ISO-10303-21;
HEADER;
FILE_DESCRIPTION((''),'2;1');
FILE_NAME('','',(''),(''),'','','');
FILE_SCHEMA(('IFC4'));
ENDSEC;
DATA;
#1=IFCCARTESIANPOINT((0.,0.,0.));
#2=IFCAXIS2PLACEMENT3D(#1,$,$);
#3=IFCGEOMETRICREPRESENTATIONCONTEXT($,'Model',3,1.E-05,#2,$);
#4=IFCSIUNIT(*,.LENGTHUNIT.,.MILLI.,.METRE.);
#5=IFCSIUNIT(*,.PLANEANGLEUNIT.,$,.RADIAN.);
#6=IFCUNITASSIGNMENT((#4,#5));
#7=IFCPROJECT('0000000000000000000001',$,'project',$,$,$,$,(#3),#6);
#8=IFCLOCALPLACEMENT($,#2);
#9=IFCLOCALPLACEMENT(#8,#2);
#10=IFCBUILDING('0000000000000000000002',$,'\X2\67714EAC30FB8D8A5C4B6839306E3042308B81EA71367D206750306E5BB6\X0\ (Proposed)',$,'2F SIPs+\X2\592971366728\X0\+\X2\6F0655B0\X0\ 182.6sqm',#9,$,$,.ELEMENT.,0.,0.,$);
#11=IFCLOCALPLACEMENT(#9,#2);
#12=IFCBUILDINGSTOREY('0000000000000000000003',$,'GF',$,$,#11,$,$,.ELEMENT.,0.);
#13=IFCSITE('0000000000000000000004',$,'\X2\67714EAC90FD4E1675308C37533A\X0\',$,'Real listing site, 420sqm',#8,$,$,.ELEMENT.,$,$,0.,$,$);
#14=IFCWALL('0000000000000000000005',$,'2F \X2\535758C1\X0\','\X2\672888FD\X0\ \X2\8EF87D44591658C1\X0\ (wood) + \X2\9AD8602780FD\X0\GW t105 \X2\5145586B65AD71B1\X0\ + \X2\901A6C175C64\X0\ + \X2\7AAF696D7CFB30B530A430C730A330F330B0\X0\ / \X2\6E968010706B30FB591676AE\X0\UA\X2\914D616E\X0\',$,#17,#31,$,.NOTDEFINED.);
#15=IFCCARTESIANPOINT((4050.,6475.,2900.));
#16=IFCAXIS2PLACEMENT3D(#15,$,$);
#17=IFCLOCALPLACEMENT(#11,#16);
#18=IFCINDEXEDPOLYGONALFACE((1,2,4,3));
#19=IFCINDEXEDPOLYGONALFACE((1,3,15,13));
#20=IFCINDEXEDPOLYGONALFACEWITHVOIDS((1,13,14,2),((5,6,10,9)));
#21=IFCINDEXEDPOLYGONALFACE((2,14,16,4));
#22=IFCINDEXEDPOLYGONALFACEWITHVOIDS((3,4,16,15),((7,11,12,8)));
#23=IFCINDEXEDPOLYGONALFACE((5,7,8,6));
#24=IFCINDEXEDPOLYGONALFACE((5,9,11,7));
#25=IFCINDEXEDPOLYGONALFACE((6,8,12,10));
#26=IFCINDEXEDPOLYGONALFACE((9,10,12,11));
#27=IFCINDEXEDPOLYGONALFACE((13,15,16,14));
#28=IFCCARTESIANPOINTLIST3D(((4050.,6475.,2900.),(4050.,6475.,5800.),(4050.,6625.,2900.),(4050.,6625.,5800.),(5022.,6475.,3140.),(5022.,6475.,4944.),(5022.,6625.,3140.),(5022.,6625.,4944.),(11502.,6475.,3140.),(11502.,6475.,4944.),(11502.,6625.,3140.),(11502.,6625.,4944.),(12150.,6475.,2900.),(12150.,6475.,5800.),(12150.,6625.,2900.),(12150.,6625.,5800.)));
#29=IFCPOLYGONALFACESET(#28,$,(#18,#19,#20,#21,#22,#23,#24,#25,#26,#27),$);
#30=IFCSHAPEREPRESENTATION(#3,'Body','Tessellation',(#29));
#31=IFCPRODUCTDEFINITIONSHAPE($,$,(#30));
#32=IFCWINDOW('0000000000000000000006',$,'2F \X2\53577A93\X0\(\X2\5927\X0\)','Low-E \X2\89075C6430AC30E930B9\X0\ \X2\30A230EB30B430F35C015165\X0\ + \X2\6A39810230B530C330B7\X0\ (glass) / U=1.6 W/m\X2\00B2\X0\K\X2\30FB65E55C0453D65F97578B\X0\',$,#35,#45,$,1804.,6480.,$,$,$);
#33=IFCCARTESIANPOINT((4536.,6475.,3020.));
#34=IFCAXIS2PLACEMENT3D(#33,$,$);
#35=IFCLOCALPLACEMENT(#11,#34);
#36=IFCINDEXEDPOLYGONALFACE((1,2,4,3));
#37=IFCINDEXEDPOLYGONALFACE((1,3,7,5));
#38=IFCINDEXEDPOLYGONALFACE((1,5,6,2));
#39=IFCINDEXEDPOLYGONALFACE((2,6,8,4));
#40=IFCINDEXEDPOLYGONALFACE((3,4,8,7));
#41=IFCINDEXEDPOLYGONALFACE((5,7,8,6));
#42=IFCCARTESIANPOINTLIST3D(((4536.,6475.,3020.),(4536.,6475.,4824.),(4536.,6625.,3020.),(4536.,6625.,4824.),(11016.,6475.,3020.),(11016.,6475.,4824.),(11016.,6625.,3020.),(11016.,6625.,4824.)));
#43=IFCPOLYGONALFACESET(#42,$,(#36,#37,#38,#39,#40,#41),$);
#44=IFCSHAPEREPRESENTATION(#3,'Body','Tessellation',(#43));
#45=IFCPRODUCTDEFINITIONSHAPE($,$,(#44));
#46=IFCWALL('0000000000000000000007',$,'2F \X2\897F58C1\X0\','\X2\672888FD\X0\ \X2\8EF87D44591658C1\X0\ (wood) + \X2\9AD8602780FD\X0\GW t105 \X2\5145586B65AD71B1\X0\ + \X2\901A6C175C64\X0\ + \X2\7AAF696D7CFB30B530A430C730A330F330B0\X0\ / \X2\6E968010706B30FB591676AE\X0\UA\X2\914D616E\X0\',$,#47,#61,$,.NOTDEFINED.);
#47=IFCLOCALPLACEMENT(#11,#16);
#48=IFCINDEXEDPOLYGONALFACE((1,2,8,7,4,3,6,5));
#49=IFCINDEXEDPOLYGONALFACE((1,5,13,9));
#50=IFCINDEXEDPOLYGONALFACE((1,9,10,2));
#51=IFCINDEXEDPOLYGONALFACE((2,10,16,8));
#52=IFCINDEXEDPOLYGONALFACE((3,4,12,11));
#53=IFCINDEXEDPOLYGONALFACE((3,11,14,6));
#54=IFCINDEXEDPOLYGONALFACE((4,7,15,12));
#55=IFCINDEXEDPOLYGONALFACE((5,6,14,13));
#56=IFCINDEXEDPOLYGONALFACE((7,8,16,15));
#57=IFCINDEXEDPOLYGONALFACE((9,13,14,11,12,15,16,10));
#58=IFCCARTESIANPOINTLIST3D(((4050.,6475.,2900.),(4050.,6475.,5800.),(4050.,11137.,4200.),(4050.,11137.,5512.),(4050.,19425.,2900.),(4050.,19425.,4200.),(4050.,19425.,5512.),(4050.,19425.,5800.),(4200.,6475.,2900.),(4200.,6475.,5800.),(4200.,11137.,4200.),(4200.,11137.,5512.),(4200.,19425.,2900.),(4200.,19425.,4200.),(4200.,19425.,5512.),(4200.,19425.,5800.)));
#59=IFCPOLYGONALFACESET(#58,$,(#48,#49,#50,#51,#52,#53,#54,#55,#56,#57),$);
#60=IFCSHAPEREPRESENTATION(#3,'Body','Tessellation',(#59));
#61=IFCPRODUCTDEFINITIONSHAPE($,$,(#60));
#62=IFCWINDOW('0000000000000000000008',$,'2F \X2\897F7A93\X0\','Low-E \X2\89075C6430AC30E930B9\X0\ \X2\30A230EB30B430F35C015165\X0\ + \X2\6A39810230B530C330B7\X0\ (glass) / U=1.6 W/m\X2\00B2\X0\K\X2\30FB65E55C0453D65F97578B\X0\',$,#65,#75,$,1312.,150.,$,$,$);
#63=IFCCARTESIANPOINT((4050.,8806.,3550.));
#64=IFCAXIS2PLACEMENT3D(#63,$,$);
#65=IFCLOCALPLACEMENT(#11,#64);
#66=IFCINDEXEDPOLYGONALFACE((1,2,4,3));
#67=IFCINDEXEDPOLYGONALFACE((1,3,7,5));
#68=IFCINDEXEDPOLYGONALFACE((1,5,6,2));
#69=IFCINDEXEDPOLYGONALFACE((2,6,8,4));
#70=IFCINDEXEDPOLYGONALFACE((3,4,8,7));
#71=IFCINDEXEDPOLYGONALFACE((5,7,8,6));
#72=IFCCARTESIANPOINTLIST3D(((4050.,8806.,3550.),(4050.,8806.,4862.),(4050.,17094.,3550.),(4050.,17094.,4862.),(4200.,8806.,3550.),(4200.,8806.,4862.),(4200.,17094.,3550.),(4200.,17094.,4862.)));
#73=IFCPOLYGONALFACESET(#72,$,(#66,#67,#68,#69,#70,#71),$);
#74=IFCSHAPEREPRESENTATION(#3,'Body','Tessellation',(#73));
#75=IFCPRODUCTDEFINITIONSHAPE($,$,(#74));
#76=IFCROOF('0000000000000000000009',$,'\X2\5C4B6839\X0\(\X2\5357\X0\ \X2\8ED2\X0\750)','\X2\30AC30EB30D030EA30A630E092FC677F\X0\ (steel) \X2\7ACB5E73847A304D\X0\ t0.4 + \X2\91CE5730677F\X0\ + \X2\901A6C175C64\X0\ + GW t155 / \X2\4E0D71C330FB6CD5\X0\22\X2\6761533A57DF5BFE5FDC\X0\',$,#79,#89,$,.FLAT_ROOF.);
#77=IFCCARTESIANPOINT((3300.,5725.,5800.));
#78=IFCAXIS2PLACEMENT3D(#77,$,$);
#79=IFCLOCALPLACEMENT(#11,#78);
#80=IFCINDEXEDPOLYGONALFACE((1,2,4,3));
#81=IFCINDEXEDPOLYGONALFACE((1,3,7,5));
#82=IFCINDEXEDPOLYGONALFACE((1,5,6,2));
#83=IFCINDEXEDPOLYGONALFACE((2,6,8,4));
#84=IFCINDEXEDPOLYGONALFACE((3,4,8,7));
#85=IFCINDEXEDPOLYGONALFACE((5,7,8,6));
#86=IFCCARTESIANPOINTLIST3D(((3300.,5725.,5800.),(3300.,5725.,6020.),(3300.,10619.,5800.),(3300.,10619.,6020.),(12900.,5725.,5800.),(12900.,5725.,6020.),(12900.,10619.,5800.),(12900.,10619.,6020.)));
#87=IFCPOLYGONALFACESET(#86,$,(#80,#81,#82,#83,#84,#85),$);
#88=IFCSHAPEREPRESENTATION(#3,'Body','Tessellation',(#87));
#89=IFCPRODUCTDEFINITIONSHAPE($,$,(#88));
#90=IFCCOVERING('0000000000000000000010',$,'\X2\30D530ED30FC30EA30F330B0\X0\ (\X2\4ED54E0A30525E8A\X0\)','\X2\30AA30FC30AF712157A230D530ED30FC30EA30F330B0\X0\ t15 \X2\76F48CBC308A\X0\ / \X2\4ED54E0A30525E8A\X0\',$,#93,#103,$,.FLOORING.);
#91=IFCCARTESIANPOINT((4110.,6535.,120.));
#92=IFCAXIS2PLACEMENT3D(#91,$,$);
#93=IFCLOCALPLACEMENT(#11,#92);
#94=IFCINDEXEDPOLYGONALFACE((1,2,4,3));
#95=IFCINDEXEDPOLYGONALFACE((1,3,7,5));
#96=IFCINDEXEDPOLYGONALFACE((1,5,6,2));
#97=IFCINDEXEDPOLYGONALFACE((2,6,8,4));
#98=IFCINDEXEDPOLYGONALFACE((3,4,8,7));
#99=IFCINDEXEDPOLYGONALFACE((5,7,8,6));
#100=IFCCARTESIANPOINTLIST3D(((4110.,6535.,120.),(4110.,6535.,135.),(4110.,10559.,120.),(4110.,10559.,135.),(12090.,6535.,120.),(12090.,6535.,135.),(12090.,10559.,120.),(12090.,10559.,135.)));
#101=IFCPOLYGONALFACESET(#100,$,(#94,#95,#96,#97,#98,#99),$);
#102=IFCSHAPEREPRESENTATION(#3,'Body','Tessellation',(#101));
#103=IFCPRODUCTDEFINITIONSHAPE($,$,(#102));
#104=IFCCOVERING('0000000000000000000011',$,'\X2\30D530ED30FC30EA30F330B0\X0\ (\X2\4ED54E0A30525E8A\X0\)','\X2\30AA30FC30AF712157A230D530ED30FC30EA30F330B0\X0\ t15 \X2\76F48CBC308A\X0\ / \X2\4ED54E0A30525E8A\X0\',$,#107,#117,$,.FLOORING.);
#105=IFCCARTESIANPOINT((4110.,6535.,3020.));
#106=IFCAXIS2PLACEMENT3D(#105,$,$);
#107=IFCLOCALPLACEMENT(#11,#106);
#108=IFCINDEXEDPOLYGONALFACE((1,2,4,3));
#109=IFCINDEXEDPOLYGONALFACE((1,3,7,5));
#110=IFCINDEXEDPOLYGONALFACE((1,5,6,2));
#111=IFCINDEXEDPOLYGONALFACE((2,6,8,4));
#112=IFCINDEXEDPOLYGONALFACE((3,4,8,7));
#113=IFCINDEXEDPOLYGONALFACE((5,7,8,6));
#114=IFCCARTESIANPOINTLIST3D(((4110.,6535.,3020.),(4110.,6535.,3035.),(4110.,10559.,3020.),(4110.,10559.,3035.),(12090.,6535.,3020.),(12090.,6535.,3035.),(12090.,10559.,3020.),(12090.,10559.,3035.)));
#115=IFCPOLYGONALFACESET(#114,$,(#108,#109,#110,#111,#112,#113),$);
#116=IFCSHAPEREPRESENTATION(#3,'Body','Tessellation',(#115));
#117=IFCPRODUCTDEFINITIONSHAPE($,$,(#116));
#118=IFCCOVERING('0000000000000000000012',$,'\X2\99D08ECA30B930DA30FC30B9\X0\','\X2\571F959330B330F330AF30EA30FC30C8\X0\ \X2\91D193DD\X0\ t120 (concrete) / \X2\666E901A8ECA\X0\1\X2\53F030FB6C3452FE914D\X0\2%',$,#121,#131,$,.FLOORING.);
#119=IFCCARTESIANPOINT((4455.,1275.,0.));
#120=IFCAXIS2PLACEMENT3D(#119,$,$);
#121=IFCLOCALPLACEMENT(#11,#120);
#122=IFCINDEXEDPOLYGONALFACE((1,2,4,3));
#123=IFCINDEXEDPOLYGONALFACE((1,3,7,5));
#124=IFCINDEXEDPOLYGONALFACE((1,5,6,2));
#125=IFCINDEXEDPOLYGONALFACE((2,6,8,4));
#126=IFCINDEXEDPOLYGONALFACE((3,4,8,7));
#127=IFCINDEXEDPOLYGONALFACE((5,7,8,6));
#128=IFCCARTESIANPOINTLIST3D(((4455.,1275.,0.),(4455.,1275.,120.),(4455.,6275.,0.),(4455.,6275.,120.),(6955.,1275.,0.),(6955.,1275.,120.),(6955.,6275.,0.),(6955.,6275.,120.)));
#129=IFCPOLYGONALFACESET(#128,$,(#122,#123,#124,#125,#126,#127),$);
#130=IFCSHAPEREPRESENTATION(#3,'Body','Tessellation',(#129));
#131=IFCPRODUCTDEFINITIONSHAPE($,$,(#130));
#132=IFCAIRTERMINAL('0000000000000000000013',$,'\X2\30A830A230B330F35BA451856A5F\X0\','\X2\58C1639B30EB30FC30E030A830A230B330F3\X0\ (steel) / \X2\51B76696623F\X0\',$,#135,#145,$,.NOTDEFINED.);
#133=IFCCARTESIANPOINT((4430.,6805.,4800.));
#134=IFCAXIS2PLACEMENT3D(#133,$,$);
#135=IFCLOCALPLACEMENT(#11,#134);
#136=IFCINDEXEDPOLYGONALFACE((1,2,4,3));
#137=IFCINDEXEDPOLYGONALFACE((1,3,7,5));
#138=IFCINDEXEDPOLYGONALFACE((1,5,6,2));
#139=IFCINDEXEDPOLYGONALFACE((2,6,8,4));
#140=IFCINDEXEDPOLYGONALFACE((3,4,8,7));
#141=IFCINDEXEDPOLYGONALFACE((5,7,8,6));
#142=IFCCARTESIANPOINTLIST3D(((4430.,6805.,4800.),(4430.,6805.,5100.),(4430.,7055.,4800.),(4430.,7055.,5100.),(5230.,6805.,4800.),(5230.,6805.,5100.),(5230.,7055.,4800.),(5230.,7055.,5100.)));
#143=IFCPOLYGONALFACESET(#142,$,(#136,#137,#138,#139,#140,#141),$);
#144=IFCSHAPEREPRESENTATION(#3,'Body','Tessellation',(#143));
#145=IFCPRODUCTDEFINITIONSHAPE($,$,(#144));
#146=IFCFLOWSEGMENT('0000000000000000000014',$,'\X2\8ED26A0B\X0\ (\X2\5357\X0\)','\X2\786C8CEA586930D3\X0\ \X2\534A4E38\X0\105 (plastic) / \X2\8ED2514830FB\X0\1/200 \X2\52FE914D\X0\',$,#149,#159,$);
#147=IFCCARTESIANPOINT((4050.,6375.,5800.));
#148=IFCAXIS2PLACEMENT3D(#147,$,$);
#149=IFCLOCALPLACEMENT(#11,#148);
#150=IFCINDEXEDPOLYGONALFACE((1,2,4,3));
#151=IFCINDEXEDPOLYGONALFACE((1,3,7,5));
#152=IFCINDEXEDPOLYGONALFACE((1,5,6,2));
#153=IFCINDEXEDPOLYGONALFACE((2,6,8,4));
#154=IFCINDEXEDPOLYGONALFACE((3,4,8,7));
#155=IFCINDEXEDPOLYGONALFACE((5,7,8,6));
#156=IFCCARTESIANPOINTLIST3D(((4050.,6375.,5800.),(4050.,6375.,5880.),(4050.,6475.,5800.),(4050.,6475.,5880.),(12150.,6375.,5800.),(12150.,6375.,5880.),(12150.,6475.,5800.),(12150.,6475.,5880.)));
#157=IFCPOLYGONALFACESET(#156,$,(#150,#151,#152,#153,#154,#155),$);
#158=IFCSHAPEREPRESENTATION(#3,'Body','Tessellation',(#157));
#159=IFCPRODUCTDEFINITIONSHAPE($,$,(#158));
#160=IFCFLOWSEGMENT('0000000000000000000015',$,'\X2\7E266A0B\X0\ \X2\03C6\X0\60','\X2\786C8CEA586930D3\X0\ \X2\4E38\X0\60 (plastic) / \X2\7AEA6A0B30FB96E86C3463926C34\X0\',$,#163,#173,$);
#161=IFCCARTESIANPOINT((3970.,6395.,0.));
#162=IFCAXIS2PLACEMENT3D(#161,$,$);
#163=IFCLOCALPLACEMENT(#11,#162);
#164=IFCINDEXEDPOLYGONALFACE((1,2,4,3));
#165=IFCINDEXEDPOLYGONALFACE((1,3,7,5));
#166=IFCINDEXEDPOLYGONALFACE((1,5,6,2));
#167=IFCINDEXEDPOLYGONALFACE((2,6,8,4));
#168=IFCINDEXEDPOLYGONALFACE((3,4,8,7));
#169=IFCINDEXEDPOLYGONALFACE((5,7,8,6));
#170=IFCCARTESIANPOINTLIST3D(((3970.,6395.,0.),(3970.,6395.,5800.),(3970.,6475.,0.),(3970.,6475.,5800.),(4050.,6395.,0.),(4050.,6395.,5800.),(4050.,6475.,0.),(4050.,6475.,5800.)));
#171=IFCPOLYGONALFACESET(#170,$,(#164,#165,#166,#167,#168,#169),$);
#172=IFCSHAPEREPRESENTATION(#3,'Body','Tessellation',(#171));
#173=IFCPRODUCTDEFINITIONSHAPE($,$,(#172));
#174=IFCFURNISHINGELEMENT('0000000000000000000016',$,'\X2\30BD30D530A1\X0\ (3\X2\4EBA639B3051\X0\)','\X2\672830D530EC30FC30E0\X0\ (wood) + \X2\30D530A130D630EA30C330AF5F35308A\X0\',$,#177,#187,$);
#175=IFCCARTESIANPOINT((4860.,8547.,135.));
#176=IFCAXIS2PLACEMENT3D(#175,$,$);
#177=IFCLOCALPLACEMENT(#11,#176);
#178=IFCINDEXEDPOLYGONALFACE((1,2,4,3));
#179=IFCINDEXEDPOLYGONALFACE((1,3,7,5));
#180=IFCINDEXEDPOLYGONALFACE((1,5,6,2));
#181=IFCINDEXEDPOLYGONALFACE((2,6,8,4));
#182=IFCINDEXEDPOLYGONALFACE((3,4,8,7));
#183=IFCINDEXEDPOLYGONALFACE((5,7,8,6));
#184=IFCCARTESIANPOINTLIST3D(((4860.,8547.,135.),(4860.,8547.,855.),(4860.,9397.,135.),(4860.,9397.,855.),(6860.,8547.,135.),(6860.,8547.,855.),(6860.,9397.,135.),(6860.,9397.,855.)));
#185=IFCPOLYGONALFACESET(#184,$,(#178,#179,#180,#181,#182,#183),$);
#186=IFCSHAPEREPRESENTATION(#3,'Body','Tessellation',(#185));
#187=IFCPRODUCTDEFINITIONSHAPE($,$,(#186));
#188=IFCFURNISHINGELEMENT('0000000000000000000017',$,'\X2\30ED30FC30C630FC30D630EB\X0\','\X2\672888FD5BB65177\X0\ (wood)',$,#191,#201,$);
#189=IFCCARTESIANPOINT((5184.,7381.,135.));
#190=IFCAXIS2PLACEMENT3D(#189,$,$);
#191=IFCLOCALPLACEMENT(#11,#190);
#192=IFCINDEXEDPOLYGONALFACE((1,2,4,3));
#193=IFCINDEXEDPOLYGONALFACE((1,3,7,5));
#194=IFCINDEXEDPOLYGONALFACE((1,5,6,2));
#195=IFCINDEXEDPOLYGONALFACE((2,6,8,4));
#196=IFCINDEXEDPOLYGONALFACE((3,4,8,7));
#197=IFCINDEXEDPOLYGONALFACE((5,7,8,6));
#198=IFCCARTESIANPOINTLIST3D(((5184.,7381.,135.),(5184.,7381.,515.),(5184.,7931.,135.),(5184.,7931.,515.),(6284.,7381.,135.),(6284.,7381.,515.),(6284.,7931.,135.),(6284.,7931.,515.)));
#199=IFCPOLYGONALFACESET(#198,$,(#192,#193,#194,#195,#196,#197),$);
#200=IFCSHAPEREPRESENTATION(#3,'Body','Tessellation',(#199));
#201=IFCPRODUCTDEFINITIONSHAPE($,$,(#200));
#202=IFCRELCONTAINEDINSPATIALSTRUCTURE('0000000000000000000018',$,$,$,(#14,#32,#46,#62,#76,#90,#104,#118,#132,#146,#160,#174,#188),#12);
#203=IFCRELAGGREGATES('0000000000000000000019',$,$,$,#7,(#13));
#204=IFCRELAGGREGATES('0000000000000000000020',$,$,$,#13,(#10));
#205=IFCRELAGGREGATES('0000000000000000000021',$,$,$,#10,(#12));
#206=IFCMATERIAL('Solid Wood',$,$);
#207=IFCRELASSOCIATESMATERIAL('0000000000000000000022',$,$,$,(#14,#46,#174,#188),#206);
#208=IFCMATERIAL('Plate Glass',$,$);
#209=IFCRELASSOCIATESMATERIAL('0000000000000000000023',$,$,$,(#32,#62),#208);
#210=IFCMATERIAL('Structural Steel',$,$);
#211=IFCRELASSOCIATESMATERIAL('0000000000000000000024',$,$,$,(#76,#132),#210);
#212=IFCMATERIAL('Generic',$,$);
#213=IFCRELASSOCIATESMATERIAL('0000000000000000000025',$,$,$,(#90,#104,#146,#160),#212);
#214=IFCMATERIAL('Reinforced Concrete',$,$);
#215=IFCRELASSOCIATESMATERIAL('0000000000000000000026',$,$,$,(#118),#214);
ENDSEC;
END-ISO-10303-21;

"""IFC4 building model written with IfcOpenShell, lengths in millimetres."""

from ifc_helpers import new_model, si_unit, frame, frame_2d, origin, place, context, project, spatial, rectangle, extrude, material, element, fill, save


model = new_model("IFC4")

# Units and contexts
model_context = context("Model", 3, precision=1e-05, world=origin())
ifc_project = project(units=[si_unit("LENGTHUNIT", "METRE", prefix="MILLI"), si_unit("PLANEANGLEUNIT", "RADIAN")], contexts=[model_context])

# Site, building, storey
site_placement = place(None, origin())
site = spatial("IfcSite", under=ifc_project, at=site_placement, Name="東京都世田谷区", ObjectType="Real listing site, 420sqm", CompositionType="ELEMENT", RefElevation=0.0)
building_placement = place(site_placement, origin())
building = spatial("IfcBuilding", under=site, at=building_placement, Name="東京・越屋根のある自然素材の家 (Proposed)", ObjectType="2F SIPs+天然木+漆喰 182.6sqm", CompositionType="ELEMENT", ElevationOfRefHeight=0.0, ElevationOfTerrain=0.0)
storey_placement = place(building_placement, origin())
storey = spatial("IfcBuildingStorey", under=building, at=storey_placement, Name="GF", CompositionType="ELEMENT", Elevation=0.0)

# Shared definitions
ifc_material_1 = material(Name="Solid Wood")

# Shared definitions
ifc_material_2 = material(Name="Reinforced Concrete")

# Shared definitions
ifc_material_3 = material(Name="Plate Glass")

# Walls, openings, windows
wall_1_placement = place(storey_placement, frame((4050.0, 6475.0, 2900.0)))
wall_1 = element("IfcWall", 1, at=wall_1_placement, inside=storey, material=ifc_material_1, Name="2F 南壁", Description="木製 軸組外壁 (wood) + 高性能GW t105 充填断熱 + 通気層 + 窯業系サイディング / 準耐火・外皮UA配慮", PredefinedType="NOTDEFINED", context=model_context, shape_type="SweptSolid", body=[
    extrude(rectangle(XDim=8100.0, YDim=150.0, at=frame_2d((4050.0, 75.0))), frame((4050.0, 6475.0, 2900.0)), (0.0, 0.0, 1.0), 2900.0),
])
opening_1_placement = place(storey_placement, frame((4536.0, 6475.0, 3020.0)))
opening_1 = element("IfcOpeningElement", 2, at=opening_1_placement, cuts=wall_1, PredefinedType="NOTDEFINED", context=model_context, shape_type="SweptSolid", body=[
    extrude(rectangle(XDim=6480.0, YDim=150.0, at=frame_2d((3240.0, 75.0))), frame((4536.0, 6475.0, 3020.0)), (0.0, 0.0, 1.0), 1804.0),
])
window_1_placement = place(storey_placement, frame((4536.0, 6475.0, 3020.0)))
window_1 = element("IfcWindow", 3, at=window_1_placement, inside=storey, material=ifc_material_3, Name="2F 南窓(大)", Description="Low-E 複層ガラス アルゴン封入 + 樹脂サッシ (glass) / U=1.6 W/m²K・日射取得型", OverallHeight=1804.0, OverallWidth=6480.0, context=model_context, shape_type="SweptSolid", body=[
    extrude(rectangle(XDim=6480.0, YDim=150.0, at=frame_2d((3240.0, 75.0))), frame((4536.0, 6475.0, 3020.0)), (0.0, 0.0, 1.0), 1804.0),
])
fill(opening_1, window_1)
wall_2_placement = place(storey_placement, frame((4050.0, 6475.0, 2900.0)))
wall_2 = element("IfcWall", 4, at=wall_2_placement, inside=storey, material=ifc_material_1, Name="2F 西壁", Description="木製 軸組外壁 (wood) + 高性能GW t105 充填断熱 + 通気層 + 窯業系サイディング / 準耐火・外皮UA配慮", PredefinedType="NOTDEFINED", context=model_context, shape_type="SweptSolid", body=[
    extrude(rectangle(XDim=150.0, YDim=12950.0, at=frame_2d((75.0, 6475.0))), frame((4050.0, 6475.0, 2900.0)), (0.0, 0.0, 1.0), 2900.0),
])
opening_2_placement = place(storey_placement, frame((4050.0, 8806.0, 3550.0)))
opening_2 = element("IfcOpeningElement", 5, at=opening_2_placement, cuts=wall_2, PredefinedType="NOTDEFINED", context=model_context, shape_type="SweptSolid", body=[
    extrude(rectangle(XDim=150.0, YDim=8288.0, at=frame_2d((75.0, 4144.0))), frame((4050.0, 8806.0, 3550.0)), (0.0, 0.0, 1.0), 1312.0),
])
window_2_placement = place(storey_placement, frame((4050.0, 8806.0, 3550.0)))
window_2 = element("IfcWindow", 6, at=window_2_placement, inside=storey, material=ifc_material_3, Name="2F 西窓", Description="Low-E 複層ガラス アルゴン封入 + 樹脂サッシ (glass) / U=1.6 W/m²K・日射取得型", OverallHeight=1312.0, OverallWidth=150.0, context=model_context, shape_type="SweptSolid", body=[
    extrude(rectangle(XDim=150.0, YDim=8288.0, at=frame_2d((75.0, 4144.0))), frame((4050.0, 8806.0, 3550.0)), (0.0, 0.0, 1.0), 1312.0),
])
fill(opening_2, window_2)

# Roof
ifc_material_4 = material(Name="Structural Steel")
for number, where, name in (
    (7, (3300.0, 5725.0, 5800.0), "屋根(南 軒750)"),
):
    element("IfcRoof", number, at=place(storey_placement, frame(where)), inside=storey, material=ifc_material_4, Name=name, Description="ガルバリウム鋼板 (steel) 立平葺き t0.4 + 野地板 + 通気層 + GW t155 / 不燃・法22条区域対応", PredefinedType="FLAT_ROOF", context=model_context, shape_type="SweptSolid", body=[
        extrude(rectangle(XDim=9600.0, YDim=4894.0, at=frame_2d((4800.0, 2447.0))), frame((3300.0, 5725.0, 5800.0)), (0.0, 0.0, 1.0), 220.0),
    ])

# Coverings
ifc_material_5 = material(Name="Generic")
covering_1_placement = place(storey_placement, frame((4110.0, 6535.0, 120.0)))
element("IfcCovering", 8, at=covering_1_placement, inside=storey, material=ifc_material_5, Name="フローリング (仕上げ床)", Description="オーク無垢フローリング t15 直貼り / 仕上げ床", PredefinedType="FLOORING", context=model_context, shape_type="SweptSolid", body=[
    extrude(rectangle(XDim=7980.0, YDim=4024.0, at=frame_2d((3990.0, 2012.0))), frame((4110.0, 6535.0, 120.0)), (0.0, 0.0, 1.0), 15.0),
])
covering_2_placement = place(storey_placement, frame((4110.0, 6535.0, 3020.0)))
element("IfcCovering", 9, at=covering_2_placement, inside=storey, material=ifc_material_5, Name="フローリング (仕上げ床)", Description="オーク無垢フローリング t15 直貼り / 仕上げ床", PredefinedType="FLOORING", context=model_context, shape_type="SweptSolid", body=[
    extrude(rectangle(XDim=7980.0, YDim=4024.0, at=frame_2d((3990.0, 2012.0))), frame((4110.0, 6535.0, 3020.0)), (0.0, 0.0, 1.0), 15.0),
])
covering_3_placement = place(storey_placement, frame((4455.0, 1275.0, 0.0)))
element("IfcCovering", 10, at=covering_3_placement, inside=storey, material=ifc_material_2, Name="駐車スペース", Description="土間コンクリート 金鏝 t120 (concrete) / 普通車1台・水勾配2%", PredefinedType="FLOORING", context=model_context, shape_type="SweptSolid", body=[
    extrude(rectangle(XDim=2500.0, YDim=5000.0, at=frame_2d((1250.0, 2500.0))), frame((4455.0, 1275.0, 0.0)), (0.0, 0.0, 1.0), 120.0),
])

# Air terminal
air_terminal_placement = place(storey_placement, frame((4430.0, 6805.0, 4800.0)))
element("IfcAirTerminal", 11, at=air_terminal_placement, inside=storey, material=ifc_material_4, Name="エアコン室内機", Description="壁掛ルームエアコン (steel) / 冷暖房", PredefinedType="NOTDEFINED", context=model_context, shape_type="SweptSolid", body=[
    extrude(rectangle(XDim=800.0, YDim=250.0, at=frame_2d((400.0, 125.0))), frame((4430.0, 6805.0, 4800.0)), (0.0, 0.0, 1.0), 300.0),
])

# Flow segments
flow_segment_1_placement = place(storey_placement, frame((4050.0, 6375.0, 5800.0)))
element("IfcFlowSegment", 12, at=flow_segment_1_placement, inside=storey, material=ifc_material_5, Name="軒樋 (南)", Description="硬質塩ビ 半丸105 (plastic) / 軒先・1/200 勾配", context=model_context, shape_type="SweptSolid", body=[
    extrude(rectangle(XDim=8100.0, YDim=100.0, at=frame_2d((4050.0, 50.0))), frame((4050.0, 6375.0, 5800.0)), (0.0, 0.0, 1.0), 80.0),
])
flow_segment_2_placement = place(storey_placement, frame((3970.0, 6395.0, 0.0)))
element("IfcFlowSegment", 13, at=flow_segment_2_placement, inside=storey, material=ifc_material_5, Name="縦樋 φ60", Description="硬質塩ビ 丸60 (plastic) / 竪樋・雨水排水", context=model_context, shape_type="SweptSolid", body=[
    extrude(rectangle(XDim=80.0, YDim=80.0, at=frame_2d((40.0, 40.0))), frame((3970.0, 6395.0, 0.0)), (0.0, 0.0, 1.0), 5800.0),
])

# Furnishing elements
furnishing_1_placement = place(storey_placement, frame((4860.0, 8547.0, 135.0)))
element("IfcFurnishingElement", 14, at=furnishing_1_placement, inside=storey, material=ifc_material_1, Name="ソファ (3人掛け)", Description="木フレーム (wood) + ファブリック張り", context=model_context, shape_type="SweptSolid", body=[
    extrude(rectangle(XDim=2000.0, YDim=850.0, at=frame_2d((1000.0, 425.0))), frame((4860.0, 8547.0, 135.0)), (0.0, 0.0, 1.0), 720.0),
])
furnishing_2_placement = place(storey_placement, frame((5184.0, 7381.0, 135.0)))
element("IfcFurnishingElement", 15, at=furnishing_2_placement, inside=storey, material=ifc_material_1, Name="ローテーブル", Description="木製家具 (wood)", context=model_context, shape_type="SweptSolid", body=[
    extrude(rectangle(XDim=1100.0, YDim=550.0, at=frame_2d((550.0, 275.0))), frame((5184.0, 7381.0, 135.0)), (0.0, 0.0, 1.0), 380.0),
])

save(model, "model.ifc")
